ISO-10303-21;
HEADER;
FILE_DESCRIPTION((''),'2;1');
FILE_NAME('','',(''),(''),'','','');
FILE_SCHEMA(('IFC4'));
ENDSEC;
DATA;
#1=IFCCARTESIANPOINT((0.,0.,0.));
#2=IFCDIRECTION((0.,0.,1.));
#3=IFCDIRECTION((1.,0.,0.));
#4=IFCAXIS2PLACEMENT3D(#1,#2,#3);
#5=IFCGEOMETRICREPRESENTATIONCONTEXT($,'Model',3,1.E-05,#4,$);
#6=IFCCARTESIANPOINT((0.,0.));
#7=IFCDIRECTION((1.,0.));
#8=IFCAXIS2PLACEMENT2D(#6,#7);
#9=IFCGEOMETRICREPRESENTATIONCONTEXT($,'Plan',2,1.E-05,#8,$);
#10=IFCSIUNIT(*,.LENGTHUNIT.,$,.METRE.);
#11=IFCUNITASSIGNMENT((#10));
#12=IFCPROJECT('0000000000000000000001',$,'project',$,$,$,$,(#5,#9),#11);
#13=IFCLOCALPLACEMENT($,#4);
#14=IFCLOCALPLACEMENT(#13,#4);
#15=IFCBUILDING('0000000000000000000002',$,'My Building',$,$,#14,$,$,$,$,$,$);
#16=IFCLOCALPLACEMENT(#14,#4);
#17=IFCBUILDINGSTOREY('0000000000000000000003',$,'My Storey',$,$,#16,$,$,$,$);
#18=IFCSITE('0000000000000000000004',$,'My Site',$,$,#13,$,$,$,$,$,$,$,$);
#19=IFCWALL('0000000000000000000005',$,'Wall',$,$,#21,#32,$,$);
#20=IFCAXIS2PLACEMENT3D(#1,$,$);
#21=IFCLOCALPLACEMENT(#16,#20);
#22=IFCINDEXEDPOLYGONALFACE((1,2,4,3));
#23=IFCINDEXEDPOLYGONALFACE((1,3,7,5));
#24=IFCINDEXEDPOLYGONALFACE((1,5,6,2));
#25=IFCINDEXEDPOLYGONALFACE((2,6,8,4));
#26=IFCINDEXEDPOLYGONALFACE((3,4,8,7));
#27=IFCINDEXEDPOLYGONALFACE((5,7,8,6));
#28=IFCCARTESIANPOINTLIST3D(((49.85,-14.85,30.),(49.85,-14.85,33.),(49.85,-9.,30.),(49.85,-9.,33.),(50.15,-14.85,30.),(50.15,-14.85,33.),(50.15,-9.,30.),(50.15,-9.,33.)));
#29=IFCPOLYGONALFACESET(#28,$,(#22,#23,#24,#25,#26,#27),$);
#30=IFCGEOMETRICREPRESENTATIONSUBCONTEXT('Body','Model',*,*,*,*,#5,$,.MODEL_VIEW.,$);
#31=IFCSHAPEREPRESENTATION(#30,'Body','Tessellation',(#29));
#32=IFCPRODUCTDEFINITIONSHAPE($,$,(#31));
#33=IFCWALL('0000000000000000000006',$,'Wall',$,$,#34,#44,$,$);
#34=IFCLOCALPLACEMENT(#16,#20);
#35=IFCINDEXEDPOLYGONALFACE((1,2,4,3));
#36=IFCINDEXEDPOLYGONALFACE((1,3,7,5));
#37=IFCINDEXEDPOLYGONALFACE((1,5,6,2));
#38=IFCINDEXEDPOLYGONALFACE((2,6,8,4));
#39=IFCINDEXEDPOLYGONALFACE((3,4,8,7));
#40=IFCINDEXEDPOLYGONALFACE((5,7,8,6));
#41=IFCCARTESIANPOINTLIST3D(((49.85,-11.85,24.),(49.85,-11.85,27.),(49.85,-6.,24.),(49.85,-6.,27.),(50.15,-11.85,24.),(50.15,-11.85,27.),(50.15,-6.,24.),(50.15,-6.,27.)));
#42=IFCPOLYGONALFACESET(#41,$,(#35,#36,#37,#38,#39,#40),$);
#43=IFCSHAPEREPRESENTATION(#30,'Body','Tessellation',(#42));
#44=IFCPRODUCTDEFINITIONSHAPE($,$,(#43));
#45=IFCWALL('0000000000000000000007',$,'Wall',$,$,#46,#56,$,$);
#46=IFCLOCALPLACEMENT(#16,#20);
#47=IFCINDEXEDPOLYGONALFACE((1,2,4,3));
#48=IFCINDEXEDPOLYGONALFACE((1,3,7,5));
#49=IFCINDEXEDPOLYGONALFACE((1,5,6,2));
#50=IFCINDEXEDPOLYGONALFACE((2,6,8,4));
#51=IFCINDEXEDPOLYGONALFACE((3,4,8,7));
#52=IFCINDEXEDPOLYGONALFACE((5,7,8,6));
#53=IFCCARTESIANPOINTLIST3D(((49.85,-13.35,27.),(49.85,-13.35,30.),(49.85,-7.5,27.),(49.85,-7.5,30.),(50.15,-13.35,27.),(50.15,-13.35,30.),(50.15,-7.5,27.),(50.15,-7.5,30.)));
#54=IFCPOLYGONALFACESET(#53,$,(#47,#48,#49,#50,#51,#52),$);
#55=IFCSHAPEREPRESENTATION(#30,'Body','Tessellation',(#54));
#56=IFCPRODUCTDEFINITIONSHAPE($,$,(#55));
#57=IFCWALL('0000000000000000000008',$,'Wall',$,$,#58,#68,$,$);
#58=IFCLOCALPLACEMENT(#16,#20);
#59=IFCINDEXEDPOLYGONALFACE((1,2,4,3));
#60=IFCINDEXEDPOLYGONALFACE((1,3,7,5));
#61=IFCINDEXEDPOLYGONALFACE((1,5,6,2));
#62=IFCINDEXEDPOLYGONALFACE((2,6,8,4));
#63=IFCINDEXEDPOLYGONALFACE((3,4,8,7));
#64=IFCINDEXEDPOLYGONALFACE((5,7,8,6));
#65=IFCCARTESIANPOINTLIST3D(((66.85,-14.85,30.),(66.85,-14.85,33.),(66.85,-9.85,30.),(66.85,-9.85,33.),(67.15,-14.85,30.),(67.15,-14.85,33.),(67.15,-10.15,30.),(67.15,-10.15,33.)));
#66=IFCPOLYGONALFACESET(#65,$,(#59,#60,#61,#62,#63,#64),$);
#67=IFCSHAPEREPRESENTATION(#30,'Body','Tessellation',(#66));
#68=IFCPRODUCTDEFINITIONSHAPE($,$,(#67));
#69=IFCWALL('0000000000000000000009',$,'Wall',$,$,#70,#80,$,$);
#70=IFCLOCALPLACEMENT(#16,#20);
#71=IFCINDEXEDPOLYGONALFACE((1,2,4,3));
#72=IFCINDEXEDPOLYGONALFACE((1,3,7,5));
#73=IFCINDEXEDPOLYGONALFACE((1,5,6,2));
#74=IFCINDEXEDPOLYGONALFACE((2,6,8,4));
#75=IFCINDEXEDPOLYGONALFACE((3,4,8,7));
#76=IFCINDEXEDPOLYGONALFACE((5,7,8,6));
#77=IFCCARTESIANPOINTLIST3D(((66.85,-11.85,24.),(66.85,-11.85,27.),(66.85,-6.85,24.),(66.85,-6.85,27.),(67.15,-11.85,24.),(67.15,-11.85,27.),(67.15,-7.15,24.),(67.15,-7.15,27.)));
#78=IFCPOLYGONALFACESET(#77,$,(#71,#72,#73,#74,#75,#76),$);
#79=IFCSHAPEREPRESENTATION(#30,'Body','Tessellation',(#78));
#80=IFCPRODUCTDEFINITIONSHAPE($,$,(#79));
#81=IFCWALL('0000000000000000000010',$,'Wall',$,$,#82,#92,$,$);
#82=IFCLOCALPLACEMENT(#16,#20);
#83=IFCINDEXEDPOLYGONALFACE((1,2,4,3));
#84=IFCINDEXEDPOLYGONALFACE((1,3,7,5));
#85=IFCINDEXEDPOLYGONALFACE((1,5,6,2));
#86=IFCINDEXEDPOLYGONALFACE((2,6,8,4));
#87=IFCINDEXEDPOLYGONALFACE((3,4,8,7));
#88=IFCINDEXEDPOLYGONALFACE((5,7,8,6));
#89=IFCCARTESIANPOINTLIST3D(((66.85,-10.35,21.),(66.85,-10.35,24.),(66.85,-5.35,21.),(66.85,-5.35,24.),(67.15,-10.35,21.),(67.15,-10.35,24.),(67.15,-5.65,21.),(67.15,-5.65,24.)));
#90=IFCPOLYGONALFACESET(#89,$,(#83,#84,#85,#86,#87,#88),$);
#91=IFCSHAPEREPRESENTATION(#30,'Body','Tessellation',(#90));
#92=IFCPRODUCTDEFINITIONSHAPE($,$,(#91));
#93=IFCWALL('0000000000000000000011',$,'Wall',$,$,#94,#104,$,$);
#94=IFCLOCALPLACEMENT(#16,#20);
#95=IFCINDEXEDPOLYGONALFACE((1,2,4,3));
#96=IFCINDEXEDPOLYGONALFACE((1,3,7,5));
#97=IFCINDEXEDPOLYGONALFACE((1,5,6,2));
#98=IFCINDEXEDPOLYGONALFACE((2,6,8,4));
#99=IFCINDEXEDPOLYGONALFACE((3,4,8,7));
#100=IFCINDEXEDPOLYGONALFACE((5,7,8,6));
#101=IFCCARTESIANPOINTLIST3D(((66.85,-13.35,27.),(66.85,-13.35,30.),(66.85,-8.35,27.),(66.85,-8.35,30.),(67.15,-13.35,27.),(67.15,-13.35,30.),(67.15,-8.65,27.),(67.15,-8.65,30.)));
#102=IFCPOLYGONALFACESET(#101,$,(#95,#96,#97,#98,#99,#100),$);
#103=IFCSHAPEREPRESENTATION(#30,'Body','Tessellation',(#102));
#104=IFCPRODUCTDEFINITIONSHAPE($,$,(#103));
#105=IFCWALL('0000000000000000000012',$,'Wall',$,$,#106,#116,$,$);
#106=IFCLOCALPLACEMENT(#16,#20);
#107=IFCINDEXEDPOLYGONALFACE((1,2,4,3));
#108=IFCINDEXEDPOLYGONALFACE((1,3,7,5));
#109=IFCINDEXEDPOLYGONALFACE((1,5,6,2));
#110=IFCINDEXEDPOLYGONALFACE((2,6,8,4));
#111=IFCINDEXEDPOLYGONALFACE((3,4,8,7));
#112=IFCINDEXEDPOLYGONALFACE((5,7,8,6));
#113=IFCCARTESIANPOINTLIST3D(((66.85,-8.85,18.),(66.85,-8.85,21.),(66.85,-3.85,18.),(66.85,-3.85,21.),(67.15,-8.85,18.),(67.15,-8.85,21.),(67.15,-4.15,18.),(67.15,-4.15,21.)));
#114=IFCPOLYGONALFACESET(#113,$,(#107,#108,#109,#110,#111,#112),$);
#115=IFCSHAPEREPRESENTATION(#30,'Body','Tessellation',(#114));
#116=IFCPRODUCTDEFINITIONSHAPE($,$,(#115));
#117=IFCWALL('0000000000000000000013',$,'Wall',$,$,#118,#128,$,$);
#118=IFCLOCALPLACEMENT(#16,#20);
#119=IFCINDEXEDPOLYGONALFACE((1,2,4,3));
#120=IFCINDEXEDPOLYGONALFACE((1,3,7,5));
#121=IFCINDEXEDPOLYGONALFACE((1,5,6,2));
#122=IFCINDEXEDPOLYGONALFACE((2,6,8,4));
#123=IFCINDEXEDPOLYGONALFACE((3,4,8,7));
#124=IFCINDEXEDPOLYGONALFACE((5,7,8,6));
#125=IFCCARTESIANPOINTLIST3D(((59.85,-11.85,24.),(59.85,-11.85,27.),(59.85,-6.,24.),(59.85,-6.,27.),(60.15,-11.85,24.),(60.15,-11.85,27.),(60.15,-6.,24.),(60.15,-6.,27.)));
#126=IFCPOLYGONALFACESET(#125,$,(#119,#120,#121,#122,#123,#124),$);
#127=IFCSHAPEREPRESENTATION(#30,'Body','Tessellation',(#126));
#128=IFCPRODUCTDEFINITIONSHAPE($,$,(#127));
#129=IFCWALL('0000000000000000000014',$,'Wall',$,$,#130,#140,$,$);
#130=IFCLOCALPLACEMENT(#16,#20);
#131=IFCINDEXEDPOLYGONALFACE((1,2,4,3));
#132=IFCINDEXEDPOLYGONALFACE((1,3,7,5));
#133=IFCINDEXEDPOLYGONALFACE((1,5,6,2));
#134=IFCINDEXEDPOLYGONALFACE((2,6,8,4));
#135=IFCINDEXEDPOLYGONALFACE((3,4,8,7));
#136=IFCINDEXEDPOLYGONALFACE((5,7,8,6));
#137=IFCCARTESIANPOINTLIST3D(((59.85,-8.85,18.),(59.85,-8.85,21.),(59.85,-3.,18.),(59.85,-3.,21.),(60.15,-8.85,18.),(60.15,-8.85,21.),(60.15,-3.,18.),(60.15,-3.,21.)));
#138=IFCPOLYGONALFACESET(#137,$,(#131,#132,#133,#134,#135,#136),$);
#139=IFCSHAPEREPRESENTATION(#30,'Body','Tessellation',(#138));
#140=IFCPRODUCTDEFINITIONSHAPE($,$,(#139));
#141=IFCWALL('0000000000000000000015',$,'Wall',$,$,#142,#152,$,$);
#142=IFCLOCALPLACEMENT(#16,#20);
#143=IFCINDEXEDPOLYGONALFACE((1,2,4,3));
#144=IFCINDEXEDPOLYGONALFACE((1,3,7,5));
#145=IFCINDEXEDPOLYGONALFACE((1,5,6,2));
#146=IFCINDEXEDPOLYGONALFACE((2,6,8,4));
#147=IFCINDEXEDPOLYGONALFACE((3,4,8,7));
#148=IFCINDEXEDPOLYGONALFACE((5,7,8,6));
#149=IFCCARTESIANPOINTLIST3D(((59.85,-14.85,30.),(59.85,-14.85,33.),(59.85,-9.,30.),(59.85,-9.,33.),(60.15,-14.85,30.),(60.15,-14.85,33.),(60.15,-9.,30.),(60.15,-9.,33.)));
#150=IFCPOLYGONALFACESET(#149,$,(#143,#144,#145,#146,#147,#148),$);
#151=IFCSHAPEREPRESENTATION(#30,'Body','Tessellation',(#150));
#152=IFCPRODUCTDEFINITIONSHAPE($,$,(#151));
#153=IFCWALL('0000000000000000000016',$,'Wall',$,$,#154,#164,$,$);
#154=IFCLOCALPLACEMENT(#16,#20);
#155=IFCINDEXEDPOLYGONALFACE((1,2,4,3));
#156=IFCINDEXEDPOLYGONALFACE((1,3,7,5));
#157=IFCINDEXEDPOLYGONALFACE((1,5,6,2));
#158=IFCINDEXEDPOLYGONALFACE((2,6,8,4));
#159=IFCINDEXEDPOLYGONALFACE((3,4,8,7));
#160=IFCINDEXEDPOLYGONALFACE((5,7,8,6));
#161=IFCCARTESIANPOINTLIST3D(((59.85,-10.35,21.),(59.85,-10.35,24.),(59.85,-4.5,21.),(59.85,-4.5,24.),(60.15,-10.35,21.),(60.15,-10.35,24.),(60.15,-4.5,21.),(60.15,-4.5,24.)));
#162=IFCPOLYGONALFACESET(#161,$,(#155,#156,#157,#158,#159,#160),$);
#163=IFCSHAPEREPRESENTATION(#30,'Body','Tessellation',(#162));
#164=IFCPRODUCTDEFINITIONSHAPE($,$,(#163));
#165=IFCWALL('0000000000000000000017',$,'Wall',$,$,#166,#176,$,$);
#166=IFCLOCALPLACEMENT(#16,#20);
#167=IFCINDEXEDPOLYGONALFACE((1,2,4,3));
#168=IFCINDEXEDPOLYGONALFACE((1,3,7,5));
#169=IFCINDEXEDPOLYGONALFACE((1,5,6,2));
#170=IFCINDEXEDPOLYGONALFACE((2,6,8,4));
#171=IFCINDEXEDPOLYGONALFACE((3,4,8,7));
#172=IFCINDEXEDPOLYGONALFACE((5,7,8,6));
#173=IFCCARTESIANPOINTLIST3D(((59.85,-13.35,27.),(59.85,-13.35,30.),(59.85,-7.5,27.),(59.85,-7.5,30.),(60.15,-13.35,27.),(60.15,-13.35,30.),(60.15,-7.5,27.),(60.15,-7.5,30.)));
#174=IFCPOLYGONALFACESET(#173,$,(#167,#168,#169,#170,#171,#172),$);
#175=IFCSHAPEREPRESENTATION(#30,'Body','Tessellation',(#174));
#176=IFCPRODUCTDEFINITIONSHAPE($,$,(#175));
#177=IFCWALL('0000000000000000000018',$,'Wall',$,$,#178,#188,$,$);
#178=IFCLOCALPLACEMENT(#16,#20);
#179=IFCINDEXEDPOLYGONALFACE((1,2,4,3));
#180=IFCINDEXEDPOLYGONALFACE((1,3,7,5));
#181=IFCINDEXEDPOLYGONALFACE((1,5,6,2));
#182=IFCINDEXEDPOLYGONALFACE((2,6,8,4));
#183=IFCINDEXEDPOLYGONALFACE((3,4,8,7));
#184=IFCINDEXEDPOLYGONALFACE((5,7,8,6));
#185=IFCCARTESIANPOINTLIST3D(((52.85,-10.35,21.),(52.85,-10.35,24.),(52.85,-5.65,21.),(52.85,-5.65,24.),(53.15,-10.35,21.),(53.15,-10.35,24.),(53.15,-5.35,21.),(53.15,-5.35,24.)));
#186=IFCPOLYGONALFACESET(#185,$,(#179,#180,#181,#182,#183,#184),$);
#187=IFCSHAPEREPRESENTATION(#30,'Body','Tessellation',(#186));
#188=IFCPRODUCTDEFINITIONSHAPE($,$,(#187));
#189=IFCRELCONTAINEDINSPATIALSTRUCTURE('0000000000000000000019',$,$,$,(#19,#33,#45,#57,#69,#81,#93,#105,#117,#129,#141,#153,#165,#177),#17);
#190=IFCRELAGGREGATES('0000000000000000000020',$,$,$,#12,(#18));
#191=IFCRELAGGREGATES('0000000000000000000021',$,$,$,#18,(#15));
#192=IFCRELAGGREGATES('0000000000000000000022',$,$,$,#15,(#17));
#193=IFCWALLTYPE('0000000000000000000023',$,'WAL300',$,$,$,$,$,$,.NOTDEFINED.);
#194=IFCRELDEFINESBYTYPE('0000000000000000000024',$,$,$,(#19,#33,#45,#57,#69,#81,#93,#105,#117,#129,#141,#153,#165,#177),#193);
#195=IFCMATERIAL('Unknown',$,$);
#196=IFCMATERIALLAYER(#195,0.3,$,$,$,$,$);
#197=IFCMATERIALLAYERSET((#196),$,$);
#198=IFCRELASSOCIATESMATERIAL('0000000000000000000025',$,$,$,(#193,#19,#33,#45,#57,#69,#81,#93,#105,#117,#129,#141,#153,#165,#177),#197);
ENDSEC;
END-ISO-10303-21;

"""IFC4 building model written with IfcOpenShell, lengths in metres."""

from ifc_helpers import new_model, si_unit, frame, origin_with_axes, origin_2d_with_axis, place, context, subcontext, project, spatial, line, indexed_curve, outline, extrude, material, layer, layer_set, layer_usage, type_object, element, save


model = new_model("IFC4")

# Units and contexts
model_context = context("Model", 3, precision=1e-05, world=origin_with_axes())
plan_context = context("Plan", 2, precision=1e-05, world=origin_2d_with_axis())
body_context = subcontext(model_context, "Body", "Model", "MODEL_VIEW")
ifc_project = project(units=[si_unit("LENGTHUNIT", "METRE")], contexts=[model_context, plan_context])

# Site, building, storey
site_placement = place(None, origin_with_axes())
site = spatial("IfcSite", under=ifc_project, at=site_placement, Name="My Site")
building_placement = place(site_placement, origin_with_axes())
building = spatial("IfcBuilding", under=site, at=building_placement, Name="My Building")
storey_placement = place(building_placement, origin_with_axes())
storey = spatial("IfcBuildingStorey", under=building, at=storey_placement, Name="My Storey")

# Walls
ifc_material = material(Name="Unknown")
ifc_layer = layer(ifc_material, 0.3)
ifc_layer_set = layer_set([ifc_layer])
ifc_layer_usage_1 = layer_usage(ifc_layer_set, "AXIS2", "POSITIVE", -0.15)
wall_type = type_object("IfcWallType", Name="WAL300", PredefinedType="NOTDEFINED", material=ifc_layer_set)
wall_1_placement = place(storey_placement, frame((50.0, -9.0, 30.0), z_axis=(0.0, 0.0, 1.0), x_axis=(0.0, -1.0, 0.0)))
element("IfcWall", 1, at=wall_1_placement, inside=storey, type_object=wall_type, material=ifc_layer_usage_1, Name="Wall", context=body_context, shape_type="SweptSolid", body=[
    extrude(outline(indexed_curve([(0.0, -0.15), (0.0, 0.15), (5.85, 0.15), (5.85, -0.15)], segments=[line(1, 2, 3, 4, 1)])), origin_with_axes(), (0.0, 0.0, 1.0), 3.0),
])
ifc_layer_usage_2 = layer_usage(ifc_layer_set, "AXIS2", "POSITIVE", -0.15)
wall_2_placement = place(storey_placement, frame((50.0, -6.0, 24.0), z_axis=(0.0, 0.0, 1.0), x_axis=(0.0, -1.0, 0.0)))
element("IfcWall", 2, at=wall_2_placement, inside=storey, type_object=wall_type, material=ifc_layer_usage_2, Name="Wall", context=body_context, shape_type="SweptSolid", body=[
    extrude(outline(indexed_curve([(0.0, -0.15), (0.0, 0.15), (5.85, 0.15), (5.85, -0.15)], segments=[line(1, 2, 3, 4, 1)])), origin_with_axes(), (0.0, 0.0, 1.0), 3.0),
])
ifc_layer_usage_3 = layer_usage(ifc_layer_set, "AXIS2", "POSITIVE", -0.15)
wall_3_placement = place(storey_placement, frame((50.0, -7.5, 27.0), z_axis=(0.0, 0.0, 1.0), x_axis=(0.0, -1.0, 0.0)))
element("IfcWall", 3, at=wall_3_placement, inside=storey, type_object=wall_type, material=ifc_layer_usage_3, Name="Wall", context=body_context, shape_type="SweptSolid", body=[
    extrude(outline(indexed_curve([(0.0, -0.15), (0.0, 0.15), (5.85, 0.15), (5.85, -0.15)], segments=[line(1, 2, 3, 4, 1)])), origin_with_axes(), (0.0, 0.0, 1.0), 3.0),
])
ifc_layer_usage_4 = layer_usage(ifc_layer_set, "AXIS2", "POSITIVE", -0.15)
wall_4_placement = place(storey_placement, frame((67.0, -10.0, 30.0), z_axis=(0.0, 0.0, 1.0), x_axis=(0.0, -1.0, 0.0)))
element("IfcWall", 4, at=wall_4_placement, inside=storey, type_object=wall_type, material=ifc_layer_usage_4, Name="Wall", context=body_context, shape_type="SweptSolid", body=[
    extrude(outline(indexed_curve([(-0.15, -0.15), (0.15, 0.15), (4.85, 0.15), (4.85, -0.15)], segments=[line(1, 2, 3, 4, 1)])), origin_with_axes(), (0.0, 0.0, 1.0), 3.0),
])
ifc_layer_usage_5 = layer_usage(ifc_layer_set, "AXIS2", "POSITIVE", -0.15)
wall_5_placement = place(storey_placement, frame((67.0, -7.0, 24.0), z_axis=(0.0, 0.0, 1.0), x_axis=(0.0, -1.0, 0.0)))
element("IfcWall", 5, at=wall_5_placement, inside=storey, type_object=wall_type, material=ifc_layer_usage_5, Name="Wall", context=body_context, shape_type="SweptSolid", body=[
    extrude(outline(indexed_curve([(-0.15, -0.15), (0.15, 0.15), (4.85, 0.15), (4.85, -0.15)], segments=[line(1, 2, 3, 4, 1)])), origin_with_axes(), (0.0, 0.0, 1.0), 3.0),
])
ifc_layer_usage_6 = layer_usage(ifc_layer_set, "AXIS2", "POSITIVE", -0.15)
wall_6_placement = place(storey_placement, frame((67.0, -5.5, 21.0), z_axis=(0.0, 0.0, 1.0), x_axis=(0.0, -1.0, 0.0)))
element("IfcWall", 6, at=wall_6_placement, inside=storey, type_object=wall_type, material=ifc_layer_usage_6, Name="Wall", context=body_context, shape_type="SweptSolid", body=[
    extrude(outline(indexed_curve([(-0.15, -0.15), (0.15, 0.15), (4.85, 0.15), (4.85, -0.15)], segments=[line(1, 2, 3, 4, 1)])), origin_with_axes(), (0.0, 0.0, 1.0), 3.0),
])
ifc_layer_usage_7 = layer_usage(ifc_layer_set, "AXIS2", "POSITIVE", -0.15)
wall_7_placement = place(storey_placement, frame((67.0, -8.5, 27.0), z_axis=(0.0, 0.0, 1.0), x_axis=(0.0, -1.0, 0.0)))
element("IfcWall", 7, at=wall_7_placement, inside=storey, type_object=wall_type, material=ifc_layer_usage_7, Name="Wall", context=body_context, shape_type="SweptSolid", body=[
    extrude(outline(indexed_curve([(-0.15, -0.15), (0.15, 0.15), (4.85, 0.15), (4.85, -0.15)], segments=[line(1, 2, 3, 4, 1)])), origin_with_axes(), (0.0, 0.0, 1.0), 3.0),
])
ifc_layer_usage_8 = layer_usage(ifc_layer_set, "AXIS2", "POSITIVE", -0.15)
wall_8_placement = place(storey_placement, frame((67.0, -4.0, 18.0), z_axis=(0.0, 0.0, 1.0), x_axis=(0.0, -1.0, 0.0)))
element("IfcWall", 8, at=wall_8_placement, inside=storey, type_object=wall_type, material=ifc_layer_usage_8, Name="Wall", context=body_context, shape_type="SweptSolid", body=[
    extrude(outline(indexed_curve([(-0.15, -0.15), (0.15, 0.15), (4.85, 0.15), (4.85, -0.15)], segments=[line(1, 2, 3, 4, 1)])), origin_with_axes(), (0.0, 0.0, 1.0), 3.0),
])
ifc_layer_usage_9 = layer_usage(ifc_layer_set, "AXIS2", "POSITIVE", -0.15)
wall_9_placement = place(storey_placement, frame((60.0, -12.0, 24.0), z_axis=(0.0, 0.0, 1.0), x_axis=(0.0, 1.0, 0.0)))
element("IfcWall", 9, at=wall_9_placement, inside=storey, type_object=wall_type, material=ifc_layer_usage_9, Name="Wall", context=body_context, shape_type="SweptSolid", body=[
    extrude(outline(indexed_curve([(0.15, -0.15), (0.15, 0.15), (6.0, 0.15), (6.0, -0.15)], segments=[line(1, 2, 3, 4, 1)])), origin_with_axes(), (0.0, 0.0, 1.0), 3.0),
])
ifc_layer_usage_10 = layer_usage(ifc_layer_set, "AXIS2", "POSITIVE", -0.15)
wall_10_placement = place(storey_placement, frame((60.0, -9.0, 18.0), z_axis=(0.0, 0.0, 1.0), x_axis=(0.0, 1.0, 0.0)))
element("IfcWall", 10, at=wall_10_placement, inside=storey, type_object=wall_type, material=ifc_layer_usage_10, Name="Wall", context=body_context, shape_type="SweptSolid", body=[
    extrude(outline(indexed_curve([(0.15, -0.15), (0.15, 0.15), (6.0, 0.15), (6.0, -0.15)], segments=[line(1, 2, 3, 4, 1)])), origin_with_axes(), (0.0, 0.0, 1.0), 3.0),
])
ifc_layer_usage_11 = layer_usage(ifc_layer_set, "AXIS2", "POSITIVE", -0.15)
wall_11_placement = place(storey_placement, frame((60.0, -15.0, 30.0), z_axis=(0.0, 0.0, 1.0), x_axis=(0.0, 1.0, 0.0)))
element("IfcWall", 11, at=wall_11_placement, inside=storey, type_object=wall_type, material=ifc_layer_usage_11, Name="Wall", context=body_context, shape_type="SweptSolid", body=[
    extrude(outline(indexed_curve([(0.15, -0.15), (0.15, 0.15), (6.0, 0.15), (6.0, -0.15)], segments=[line(1, 2, 3, 4, 1)])), origin_with_axes(), (0.0, 0.0, 1.0), 3.0),
])
ifc_layer_usage_12 = layer_usage(ifc_layer_set, "AXIS2", "POSITIVE", -0.15)
wall_12_placement = place(storey_placement, frame((60.0, -10.5, 21.0), z_axis=(0.0, 0.0, 1.0), x_axis=(0.0, 1.0, 0.0)))
element("IfcWall", 12, at=wall_12_placement, inside=storey, type_object=wall_type, material=ifc_layer_usage_12, Name="Wall", context=body_context, shape_type="SweptSolid", body=[
    extrude(outline(indexed_curve([(0.15, -0.15), (0.15, 0.15), (6.0, 0.15), (6.0, -0.15)], segments=[line(1, 2, 3, 4, 1)])), origin_with_axes(), (0.0, 0.0, 1.0), 3.0),
])
ifc_layer_usage_13 = layer_usage(ifc_layer_set, "AXIS2", "POSITIVE", -0.15)
wall_13_placement = place(storey_placement, frame((60.0, -13.5, 27.0), z_axis=(0.0, 0.0, 1.0), x_axis=(0.0, 1.0, 0.0)))
element("IfcWall", 13, at=wall_13_placement, inside=storey, type_object=wall_type, material=ifc_layer_usage_13, Name="Wall", context=body_context, shape_type="SweptSolid", body=[
    extrude(outline(indexed_curve([(0.15, -0.15), (0.15, 0.15), (6.0, 0.15), (6.0, -0.15)], segments=[line(1, 2, 3, 4, 1)])), origin_with_axes(), (0.0, 0.0, 1.0), 3.0),
])
ifc_layer_usage_14 = layer_usage(ifc_layer_set, "AXIS2", "POSITIVE", -0.15)
wall_14_placement = place(storey_placement, frame((53.0, -10.5, 21.0), z_axis=(0.0, 0.0, 1.0), x_axis=(0.0, 1.0, 0.0)))
element("IfcWall", 14, at=wall_14_placement, inside=storey, type_object=wall_type, material=ifc_layer_usage_14, Name="Wall", context=body_context, shape_type="SweptSolid", body=[
    extrude(outline(indexed_curve([(0.15, -0.15), (0.15, 0.15), (4.85, 0.15), (5.15, -0.15)], segments=[line(1, 2, 3, 4, 1)])), origin_with_axes(), (0.0, 0.0, 1.0), 3.0),
])

save(model, "model.ifc")
